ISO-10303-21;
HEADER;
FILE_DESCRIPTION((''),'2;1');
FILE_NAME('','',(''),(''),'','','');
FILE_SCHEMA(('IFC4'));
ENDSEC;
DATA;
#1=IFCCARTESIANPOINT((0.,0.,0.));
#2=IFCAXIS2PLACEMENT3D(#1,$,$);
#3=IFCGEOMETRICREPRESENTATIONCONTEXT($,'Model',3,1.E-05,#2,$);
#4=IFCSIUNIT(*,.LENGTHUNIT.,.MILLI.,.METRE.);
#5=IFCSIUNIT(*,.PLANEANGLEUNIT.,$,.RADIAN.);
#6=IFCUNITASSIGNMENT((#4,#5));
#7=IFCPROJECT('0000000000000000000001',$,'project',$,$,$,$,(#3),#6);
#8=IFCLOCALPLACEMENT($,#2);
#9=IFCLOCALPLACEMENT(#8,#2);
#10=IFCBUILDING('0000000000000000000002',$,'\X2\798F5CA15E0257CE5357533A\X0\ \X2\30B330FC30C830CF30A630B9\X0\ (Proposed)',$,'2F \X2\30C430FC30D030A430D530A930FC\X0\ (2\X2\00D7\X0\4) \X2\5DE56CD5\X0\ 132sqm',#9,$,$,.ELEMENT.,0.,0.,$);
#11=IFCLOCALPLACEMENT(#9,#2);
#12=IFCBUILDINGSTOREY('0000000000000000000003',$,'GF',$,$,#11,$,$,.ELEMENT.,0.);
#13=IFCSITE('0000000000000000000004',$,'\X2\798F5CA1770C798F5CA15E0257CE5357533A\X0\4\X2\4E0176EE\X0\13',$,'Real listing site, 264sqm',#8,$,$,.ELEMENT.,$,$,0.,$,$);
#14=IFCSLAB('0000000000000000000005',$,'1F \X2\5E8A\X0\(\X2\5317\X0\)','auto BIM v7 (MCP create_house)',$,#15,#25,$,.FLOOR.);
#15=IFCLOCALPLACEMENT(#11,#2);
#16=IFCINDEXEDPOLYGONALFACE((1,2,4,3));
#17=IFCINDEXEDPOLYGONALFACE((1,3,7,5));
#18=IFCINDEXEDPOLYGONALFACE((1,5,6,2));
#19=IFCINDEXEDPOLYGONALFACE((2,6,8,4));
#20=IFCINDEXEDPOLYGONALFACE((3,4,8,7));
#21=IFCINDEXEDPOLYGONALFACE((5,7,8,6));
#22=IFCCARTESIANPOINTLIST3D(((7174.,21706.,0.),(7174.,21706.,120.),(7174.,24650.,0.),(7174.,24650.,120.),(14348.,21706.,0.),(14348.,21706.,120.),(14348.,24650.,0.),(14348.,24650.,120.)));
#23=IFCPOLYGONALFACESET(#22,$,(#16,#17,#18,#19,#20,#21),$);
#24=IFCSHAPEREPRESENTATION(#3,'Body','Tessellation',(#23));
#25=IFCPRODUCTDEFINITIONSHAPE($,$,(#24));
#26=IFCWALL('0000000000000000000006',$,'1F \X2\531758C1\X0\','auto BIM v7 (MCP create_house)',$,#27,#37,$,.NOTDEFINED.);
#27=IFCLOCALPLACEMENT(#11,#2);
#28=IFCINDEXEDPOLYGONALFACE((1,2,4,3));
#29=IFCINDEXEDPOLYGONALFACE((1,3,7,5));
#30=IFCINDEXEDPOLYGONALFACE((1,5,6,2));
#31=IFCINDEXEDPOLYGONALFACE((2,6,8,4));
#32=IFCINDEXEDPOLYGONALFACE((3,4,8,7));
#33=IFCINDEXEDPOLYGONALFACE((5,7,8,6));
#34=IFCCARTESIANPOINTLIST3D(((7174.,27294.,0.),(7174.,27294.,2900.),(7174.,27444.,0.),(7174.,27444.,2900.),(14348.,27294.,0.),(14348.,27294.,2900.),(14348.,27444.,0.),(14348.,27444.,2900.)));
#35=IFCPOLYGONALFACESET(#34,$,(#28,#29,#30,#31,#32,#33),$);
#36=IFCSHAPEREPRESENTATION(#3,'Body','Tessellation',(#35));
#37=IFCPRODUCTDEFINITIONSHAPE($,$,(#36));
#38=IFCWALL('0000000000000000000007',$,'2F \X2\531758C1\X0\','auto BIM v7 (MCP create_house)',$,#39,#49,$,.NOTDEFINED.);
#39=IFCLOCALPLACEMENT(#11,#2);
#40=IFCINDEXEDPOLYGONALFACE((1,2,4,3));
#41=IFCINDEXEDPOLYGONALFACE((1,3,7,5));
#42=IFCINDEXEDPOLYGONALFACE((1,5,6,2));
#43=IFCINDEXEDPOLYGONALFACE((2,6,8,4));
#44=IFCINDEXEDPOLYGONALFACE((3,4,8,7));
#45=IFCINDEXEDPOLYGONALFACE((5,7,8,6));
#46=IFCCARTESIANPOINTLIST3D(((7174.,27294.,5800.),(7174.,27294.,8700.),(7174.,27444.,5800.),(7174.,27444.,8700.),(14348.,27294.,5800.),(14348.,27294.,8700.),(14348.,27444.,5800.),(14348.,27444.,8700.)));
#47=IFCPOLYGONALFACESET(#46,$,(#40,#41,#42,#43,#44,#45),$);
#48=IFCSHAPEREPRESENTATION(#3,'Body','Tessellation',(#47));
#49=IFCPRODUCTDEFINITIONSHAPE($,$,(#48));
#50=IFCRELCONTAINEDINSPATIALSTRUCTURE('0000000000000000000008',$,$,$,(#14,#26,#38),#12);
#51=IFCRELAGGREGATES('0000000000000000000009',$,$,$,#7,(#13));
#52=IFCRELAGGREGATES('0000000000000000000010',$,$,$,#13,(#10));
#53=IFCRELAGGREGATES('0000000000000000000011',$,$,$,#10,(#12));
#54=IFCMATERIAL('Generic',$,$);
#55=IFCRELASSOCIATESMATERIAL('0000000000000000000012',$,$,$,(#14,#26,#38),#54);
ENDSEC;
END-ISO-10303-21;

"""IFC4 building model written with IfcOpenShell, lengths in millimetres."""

from ifc_helpers import new_model, si_unit, frame, frame_2d, origin, place, context, project, spatial, rectangle, extrude, material, element, save


model = new_model("IFC4")

# Units and contexts
model_context = context("Model", 3, precision=1e-05, world=origin())
ifc_project = project(units=[si_unit("LENGTHUNIT", "METRE", prefix="MILLI"), si_unit("PLANEANGLEUNIT", "RADIAN")], contexts=[model_context])

# Site, building, storey
site_placement = place(None, origin())
site = spatial("IfcSite", under=ifc_project, at=site_placement, Name="福岡県福岡市城南区4丁目13", ObjectType="Real listing site, 264sqm", CompositionType="ELEMENT", RefElevation=0.0)
building_placement = place(site_placement, origin())
building = spatial("IfcBuilding", under=site, at=building_placement, Name="福岡市城南区 コートハウス (Proposed)", ObjectType="2F ツーバイフォー (2×4) 工法 132sqm", CompositionType="ELEMENT", ElevationOfRefHeight=0.0, ElevationOfTerrain=0.0)
storey_placement = place(building_placement, origin())
storey = spatial("IfcBuildingStorey", under=building, at=storey_placement, Name="GF", CompositionType="ELEMENT", Elevation=0.0)

# Slab
ifc_material = material(Name="Generic")
slab_1_placement = place(storey_placement, frame((3587.0, 10853.0, 0.0)))
element("IfcSlab", 1, at=slab_1_placement, inside=storey, material=ifc_material, Name="1F 床(北)", Description="auto BIM v7 (MCP create_house)", PredefinedType="FLOOR", context=model_context, shape_type="SweptSolid", body=[
    extrude(rectangle(XDim=7174.0, YDim=2944.0, at=frame_2d((3587.0, 1472.0))), frame((3587.0, 10853.0, 0.0)), (0.0, 0.0, 1.0), 120.0),
])

# Wall
wall_1_placement = place(storey_placement, frame((3587.0, 13647.0, 0.0)))
element("IfcWall", 2, at=wall_1_placement, inside=storey, material=ifc_material, Name="1F 北壁", Description="auto BIM v7 (MCP create_house)", PredefinedType="NOTDEFINED", context=model_context, shape_type="SweptSolid", body=[
    extrude(rectangle(XDim=7174.0, YDim=150.0, at=frame_2d((3587.0, 75.0))), frame((3587.0, 13647.0, 0.0)), (0.0, 0.0, 1.0), 2900.0),
])

# Wall
wall_2_placement = place(storey_placement, frame((3587.0, 13647.0, 2900.0)))
element("IfcWall", 3, at=wall_2_placement, inside=storey, material=ifc_material, Name="2F 北壁", Description="auto BIM v7 (MCP create_house)", PredefinedType="NOTDEFINED", context=model_context, shape_type="SweptSolid", body=[
    extrude(rectangle(XDim=7174.0, YDim=150.0, at=frame_2d((3587.0, 75.0))), frame((3587.0, 13647.0, 2900.0)), (0.0, 0.0, 1.0), 2900.0),
])

save(model, "model.ifc")
